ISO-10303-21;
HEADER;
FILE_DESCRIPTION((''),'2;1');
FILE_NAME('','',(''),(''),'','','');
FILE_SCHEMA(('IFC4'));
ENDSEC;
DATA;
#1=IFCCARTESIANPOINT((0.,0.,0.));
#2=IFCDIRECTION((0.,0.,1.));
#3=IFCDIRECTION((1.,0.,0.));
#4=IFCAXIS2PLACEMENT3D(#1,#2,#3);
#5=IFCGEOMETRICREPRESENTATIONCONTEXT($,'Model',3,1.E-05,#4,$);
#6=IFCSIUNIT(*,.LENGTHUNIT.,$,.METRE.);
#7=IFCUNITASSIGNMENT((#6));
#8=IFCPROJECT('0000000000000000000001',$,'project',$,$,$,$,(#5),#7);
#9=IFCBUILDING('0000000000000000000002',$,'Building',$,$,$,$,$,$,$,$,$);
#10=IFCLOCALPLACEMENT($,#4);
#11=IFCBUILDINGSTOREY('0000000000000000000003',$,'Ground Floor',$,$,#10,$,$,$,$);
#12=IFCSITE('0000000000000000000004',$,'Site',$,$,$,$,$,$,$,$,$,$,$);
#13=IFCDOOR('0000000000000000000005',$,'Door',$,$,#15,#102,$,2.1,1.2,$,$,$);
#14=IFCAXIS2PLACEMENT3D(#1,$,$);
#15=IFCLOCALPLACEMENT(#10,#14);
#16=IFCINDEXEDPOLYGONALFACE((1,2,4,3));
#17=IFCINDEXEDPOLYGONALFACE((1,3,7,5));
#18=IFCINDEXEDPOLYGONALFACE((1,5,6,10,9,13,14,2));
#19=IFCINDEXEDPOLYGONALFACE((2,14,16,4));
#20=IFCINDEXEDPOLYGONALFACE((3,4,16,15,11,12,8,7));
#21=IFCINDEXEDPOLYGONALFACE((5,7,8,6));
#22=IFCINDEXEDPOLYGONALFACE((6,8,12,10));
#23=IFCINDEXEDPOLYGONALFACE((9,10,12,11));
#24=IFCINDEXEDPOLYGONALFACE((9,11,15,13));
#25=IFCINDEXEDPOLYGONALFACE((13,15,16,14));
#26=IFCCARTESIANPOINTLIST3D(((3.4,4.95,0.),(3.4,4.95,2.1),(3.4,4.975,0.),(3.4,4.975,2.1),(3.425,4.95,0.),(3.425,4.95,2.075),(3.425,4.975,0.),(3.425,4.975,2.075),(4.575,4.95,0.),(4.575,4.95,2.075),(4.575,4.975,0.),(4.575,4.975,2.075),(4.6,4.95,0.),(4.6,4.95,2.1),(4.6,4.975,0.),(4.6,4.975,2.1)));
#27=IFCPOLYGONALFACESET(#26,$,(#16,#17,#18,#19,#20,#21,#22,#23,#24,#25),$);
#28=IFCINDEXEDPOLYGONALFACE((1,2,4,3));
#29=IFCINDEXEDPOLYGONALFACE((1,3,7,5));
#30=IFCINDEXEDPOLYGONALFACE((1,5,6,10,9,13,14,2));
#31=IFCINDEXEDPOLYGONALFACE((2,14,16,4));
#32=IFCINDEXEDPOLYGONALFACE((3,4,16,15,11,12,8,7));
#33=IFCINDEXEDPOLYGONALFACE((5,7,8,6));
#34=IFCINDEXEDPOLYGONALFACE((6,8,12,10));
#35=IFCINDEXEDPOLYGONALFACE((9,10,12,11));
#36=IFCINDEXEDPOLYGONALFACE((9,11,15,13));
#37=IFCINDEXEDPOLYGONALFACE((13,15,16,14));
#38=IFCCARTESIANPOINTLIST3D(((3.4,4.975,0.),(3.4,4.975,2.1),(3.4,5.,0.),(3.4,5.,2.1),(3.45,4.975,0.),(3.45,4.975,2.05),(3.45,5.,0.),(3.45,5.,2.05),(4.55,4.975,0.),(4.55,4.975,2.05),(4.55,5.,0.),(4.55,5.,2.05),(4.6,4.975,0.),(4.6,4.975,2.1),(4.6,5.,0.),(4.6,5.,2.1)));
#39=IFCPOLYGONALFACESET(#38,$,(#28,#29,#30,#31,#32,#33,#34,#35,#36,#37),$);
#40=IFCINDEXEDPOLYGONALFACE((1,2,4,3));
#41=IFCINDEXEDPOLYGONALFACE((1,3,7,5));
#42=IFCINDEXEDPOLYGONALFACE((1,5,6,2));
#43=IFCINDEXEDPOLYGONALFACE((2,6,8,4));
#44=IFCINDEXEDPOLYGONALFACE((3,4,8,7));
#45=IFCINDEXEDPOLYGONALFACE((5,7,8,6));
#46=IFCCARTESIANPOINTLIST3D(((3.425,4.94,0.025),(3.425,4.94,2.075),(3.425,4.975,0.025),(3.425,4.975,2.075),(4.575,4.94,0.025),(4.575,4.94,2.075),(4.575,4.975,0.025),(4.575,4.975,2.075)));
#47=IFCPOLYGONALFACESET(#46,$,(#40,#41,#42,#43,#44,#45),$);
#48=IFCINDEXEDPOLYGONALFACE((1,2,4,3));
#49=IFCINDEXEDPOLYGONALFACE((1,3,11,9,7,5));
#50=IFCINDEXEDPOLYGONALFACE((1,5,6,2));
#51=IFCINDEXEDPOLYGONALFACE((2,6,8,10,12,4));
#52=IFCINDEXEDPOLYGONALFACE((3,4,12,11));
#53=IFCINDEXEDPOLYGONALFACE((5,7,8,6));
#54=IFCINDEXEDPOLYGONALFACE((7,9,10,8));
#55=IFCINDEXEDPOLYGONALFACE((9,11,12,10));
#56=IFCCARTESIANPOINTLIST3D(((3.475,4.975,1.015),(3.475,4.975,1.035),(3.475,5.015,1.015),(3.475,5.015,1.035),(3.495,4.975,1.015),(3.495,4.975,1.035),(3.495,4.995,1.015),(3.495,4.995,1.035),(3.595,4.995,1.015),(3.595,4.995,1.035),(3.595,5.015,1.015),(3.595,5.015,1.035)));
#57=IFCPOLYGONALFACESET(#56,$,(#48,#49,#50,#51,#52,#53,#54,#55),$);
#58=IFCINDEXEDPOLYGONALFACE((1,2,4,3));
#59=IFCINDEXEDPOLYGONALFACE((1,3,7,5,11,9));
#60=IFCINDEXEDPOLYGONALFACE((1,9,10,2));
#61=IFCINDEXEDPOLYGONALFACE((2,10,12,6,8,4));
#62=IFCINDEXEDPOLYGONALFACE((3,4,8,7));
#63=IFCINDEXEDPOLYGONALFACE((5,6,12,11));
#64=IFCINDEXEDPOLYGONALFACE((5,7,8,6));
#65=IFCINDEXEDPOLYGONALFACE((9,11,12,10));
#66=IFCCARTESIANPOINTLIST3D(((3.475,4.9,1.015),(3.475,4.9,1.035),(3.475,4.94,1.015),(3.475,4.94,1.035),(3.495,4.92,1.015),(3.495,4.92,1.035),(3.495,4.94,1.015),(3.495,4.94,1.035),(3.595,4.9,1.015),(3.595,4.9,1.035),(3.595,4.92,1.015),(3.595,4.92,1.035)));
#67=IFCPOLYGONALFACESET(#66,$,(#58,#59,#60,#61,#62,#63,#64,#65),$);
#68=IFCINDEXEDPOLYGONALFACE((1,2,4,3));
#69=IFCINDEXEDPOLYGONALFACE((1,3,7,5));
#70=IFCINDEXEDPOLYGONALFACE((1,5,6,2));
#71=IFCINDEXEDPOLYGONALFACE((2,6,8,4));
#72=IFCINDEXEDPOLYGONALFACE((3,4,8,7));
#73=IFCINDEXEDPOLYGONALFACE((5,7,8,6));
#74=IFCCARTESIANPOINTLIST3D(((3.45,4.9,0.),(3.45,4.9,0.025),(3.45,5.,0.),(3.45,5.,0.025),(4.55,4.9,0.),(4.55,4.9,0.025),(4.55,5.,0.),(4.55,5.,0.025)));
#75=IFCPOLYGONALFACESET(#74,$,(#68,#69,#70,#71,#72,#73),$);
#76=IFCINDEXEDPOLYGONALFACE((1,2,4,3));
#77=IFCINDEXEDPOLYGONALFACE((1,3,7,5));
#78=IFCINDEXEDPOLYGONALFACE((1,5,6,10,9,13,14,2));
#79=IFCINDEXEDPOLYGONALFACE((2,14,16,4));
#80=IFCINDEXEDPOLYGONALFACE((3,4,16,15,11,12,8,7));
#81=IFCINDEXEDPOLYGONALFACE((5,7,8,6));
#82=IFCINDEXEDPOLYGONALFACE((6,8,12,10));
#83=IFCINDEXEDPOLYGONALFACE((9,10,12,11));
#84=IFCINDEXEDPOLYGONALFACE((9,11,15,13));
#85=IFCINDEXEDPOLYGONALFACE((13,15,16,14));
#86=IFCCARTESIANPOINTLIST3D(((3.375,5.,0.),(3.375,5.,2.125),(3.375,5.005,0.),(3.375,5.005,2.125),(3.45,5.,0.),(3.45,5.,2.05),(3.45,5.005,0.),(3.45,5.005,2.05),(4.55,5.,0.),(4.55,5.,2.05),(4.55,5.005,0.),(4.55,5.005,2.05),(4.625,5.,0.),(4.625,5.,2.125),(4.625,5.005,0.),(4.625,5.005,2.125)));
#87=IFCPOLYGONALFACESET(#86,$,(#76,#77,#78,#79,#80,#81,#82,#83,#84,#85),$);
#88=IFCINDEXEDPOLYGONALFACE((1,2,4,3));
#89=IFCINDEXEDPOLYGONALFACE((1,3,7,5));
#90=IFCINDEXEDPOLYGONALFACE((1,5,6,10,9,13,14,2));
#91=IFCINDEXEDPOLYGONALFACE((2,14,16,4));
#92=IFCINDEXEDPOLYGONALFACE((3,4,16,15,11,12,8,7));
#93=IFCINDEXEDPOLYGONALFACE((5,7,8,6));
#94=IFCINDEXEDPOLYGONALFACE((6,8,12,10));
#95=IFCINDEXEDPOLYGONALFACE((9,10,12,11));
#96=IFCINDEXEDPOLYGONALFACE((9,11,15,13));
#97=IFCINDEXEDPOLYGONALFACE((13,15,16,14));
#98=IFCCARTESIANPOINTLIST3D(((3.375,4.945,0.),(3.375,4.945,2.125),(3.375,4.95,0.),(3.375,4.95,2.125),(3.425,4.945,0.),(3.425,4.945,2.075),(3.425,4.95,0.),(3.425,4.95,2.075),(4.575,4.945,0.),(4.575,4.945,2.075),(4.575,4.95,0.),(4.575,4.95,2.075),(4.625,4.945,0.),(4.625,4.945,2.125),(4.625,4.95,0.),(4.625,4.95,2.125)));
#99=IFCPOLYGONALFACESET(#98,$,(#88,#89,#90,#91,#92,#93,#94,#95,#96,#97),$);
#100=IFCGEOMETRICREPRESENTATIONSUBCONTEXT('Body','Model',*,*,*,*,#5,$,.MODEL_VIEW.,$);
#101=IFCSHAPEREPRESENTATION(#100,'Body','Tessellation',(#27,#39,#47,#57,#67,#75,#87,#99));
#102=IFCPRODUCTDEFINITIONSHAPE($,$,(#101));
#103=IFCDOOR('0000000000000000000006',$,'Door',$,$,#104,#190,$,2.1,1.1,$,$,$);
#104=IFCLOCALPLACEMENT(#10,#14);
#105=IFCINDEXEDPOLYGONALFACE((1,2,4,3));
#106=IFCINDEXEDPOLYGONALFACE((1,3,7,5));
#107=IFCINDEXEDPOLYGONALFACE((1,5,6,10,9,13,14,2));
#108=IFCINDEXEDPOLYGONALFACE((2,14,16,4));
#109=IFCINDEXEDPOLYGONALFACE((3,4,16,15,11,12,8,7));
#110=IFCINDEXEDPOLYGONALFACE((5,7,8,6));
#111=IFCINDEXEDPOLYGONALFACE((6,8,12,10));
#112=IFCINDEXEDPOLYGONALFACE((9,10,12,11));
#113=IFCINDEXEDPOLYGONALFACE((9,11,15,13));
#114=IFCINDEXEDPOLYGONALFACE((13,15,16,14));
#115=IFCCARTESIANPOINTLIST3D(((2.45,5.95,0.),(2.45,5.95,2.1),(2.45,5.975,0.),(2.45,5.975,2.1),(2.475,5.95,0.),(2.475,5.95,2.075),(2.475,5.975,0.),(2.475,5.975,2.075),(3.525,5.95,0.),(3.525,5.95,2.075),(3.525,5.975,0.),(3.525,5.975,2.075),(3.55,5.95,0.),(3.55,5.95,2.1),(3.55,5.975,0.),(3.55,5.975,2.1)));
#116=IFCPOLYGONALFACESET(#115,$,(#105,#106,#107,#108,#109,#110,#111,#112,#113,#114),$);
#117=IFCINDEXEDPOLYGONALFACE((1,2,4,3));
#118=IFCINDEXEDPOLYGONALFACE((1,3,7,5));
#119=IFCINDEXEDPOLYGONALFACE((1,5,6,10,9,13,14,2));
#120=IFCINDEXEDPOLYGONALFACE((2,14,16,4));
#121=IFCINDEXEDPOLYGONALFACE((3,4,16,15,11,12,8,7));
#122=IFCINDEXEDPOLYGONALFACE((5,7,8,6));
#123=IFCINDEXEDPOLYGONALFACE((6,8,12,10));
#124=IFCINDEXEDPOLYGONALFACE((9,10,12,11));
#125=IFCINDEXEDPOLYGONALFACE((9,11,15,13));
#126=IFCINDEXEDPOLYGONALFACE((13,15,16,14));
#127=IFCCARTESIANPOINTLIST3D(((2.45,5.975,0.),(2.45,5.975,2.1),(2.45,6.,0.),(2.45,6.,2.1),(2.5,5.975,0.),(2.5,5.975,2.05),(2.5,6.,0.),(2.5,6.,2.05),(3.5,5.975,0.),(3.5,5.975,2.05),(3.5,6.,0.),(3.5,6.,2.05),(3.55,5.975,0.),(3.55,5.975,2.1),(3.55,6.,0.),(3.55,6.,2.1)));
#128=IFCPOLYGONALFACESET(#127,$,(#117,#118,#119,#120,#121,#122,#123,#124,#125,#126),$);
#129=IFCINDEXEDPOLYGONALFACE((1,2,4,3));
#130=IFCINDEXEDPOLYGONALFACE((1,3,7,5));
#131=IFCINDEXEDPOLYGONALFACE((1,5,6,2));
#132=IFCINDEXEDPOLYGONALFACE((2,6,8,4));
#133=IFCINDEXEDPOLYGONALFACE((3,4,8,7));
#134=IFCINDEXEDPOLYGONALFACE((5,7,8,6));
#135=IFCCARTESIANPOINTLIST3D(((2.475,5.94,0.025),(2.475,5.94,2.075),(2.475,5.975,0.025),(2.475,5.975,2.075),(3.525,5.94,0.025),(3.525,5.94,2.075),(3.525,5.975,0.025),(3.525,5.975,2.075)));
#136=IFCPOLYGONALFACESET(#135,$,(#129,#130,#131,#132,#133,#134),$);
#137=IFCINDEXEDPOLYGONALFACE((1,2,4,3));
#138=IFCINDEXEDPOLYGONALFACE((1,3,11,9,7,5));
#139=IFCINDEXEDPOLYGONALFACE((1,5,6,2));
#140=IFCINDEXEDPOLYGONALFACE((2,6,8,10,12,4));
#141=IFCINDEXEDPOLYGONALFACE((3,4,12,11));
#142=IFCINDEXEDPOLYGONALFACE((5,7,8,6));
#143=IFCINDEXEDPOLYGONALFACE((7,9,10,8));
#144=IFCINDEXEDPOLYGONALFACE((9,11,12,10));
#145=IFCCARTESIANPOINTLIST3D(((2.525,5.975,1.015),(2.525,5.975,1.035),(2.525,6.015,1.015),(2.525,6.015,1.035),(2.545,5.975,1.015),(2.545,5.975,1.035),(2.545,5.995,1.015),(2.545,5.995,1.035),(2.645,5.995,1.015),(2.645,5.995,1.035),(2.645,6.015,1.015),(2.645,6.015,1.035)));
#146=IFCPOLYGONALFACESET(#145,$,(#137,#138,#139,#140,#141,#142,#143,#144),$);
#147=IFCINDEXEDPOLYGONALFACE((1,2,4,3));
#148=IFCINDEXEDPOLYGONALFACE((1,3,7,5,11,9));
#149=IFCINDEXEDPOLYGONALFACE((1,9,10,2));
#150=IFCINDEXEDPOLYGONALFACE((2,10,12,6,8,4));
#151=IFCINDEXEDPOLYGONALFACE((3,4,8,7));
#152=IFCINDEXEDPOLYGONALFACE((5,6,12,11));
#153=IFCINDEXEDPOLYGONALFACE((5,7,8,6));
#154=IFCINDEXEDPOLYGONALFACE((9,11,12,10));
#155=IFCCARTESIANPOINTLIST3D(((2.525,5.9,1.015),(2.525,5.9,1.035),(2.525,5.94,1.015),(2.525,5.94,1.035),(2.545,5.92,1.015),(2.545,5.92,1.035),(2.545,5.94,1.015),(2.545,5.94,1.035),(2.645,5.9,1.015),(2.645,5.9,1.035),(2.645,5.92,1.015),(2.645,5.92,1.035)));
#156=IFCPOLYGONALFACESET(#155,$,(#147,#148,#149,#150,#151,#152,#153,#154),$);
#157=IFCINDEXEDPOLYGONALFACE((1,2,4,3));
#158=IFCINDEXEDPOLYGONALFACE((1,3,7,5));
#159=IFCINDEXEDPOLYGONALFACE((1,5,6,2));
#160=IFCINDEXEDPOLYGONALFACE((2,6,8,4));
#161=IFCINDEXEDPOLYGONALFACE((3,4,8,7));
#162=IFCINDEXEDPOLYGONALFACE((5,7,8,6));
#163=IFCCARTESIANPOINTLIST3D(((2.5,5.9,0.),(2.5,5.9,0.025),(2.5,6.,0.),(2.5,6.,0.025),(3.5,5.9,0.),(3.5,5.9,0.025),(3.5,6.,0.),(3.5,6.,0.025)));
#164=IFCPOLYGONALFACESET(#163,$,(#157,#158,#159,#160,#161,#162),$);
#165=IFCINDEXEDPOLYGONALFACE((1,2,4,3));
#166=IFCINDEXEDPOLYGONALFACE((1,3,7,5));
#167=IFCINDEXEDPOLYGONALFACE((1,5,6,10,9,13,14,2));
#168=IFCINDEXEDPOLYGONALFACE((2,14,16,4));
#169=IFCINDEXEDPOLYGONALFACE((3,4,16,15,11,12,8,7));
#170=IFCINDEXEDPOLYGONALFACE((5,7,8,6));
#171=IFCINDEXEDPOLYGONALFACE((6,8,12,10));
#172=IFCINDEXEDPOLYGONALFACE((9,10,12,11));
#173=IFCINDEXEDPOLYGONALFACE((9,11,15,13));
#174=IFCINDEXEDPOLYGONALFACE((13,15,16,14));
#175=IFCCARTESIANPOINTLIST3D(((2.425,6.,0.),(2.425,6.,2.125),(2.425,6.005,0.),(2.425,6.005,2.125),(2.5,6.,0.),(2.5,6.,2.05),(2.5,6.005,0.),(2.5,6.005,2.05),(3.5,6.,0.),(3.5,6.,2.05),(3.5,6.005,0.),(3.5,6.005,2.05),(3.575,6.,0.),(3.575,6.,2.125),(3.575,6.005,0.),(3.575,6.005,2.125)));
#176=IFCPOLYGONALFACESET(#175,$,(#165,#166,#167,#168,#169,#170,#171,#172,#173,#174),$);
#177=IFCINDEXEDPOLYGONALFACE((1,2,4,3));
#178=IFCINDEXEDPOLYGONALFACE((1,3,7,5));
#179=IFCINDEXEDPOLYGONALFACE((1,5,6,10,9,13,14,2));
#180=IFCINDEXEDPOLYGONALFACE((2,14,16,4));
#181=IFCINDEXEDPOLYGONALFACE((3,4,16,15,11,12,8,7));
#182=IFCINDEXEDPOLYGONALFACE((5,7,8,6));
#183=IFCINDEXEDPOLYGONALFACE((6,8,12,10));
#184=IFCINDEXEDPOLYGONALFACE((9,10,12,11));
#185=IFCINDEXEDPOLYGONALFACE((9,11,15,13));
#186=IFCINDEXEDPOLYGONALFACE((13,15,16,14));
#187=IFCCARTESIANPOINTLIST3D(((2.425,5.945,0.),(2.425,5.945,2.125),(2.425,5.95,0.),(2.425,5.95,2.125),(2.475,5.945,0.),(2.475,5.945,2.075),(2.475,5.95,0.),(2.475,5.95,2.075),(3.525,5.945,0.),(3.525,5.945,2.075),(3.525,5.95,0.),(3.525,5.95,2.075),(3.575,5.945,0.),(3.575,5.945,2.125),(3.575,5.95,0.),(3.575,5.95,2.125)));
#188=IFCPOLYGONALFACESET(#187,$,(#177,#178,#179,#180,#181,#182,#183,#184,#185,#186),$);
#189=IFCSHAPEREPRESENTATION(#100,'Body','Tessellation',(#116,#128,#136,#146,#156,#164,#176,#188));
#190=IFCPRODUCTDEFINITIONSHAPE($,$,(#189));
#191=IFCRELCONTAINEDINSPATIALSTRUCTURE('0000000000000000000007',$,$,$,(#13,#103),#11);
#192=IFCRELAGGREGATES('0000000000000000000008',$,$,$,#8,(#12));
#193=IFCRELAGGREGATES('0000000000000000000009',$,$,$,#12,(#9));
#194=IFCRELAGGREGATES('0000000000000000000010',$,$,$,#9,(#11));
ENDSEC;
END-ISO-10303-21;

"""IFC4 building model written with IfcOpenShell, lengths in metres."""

from ifc_helpers import new_model, si_unit, frame, origin_with_axes, place, context, subcontext, project, spatial, line, indexed_curve, outline, extrude, element, save


model = new_model("IFC4")

# Units and contexts
model_context = context("Model", 3, precision=1e-05, world=origin_with_axes())
body_context = subcontext(model_context, "Body", "Model", "MODEL_VIEW")
ifc_project = project(units=[si_unit("LENGTHUNIT", "METRE")], contexts=[model_context])

# Site, building, storey
site = spatial("IfcSite", under=ifc_project, Name="Site")
building = spatial("IfcBuilding", under=site, Name="Building")
storey_placement = place(None, origin_with_axes())
storey = spatial("IfcBuildingStorey", under=building, at=storey_placement, Name="Ground Floor")

# Doors
door_1_placement = place(storey_placement, frame((4.6, 5.0, 0.0), z_axis=(0.0, 0.0, 1.0), x_axis=(-1.0, 0.0, 0.0)))
element("IfcDoor", 1, at=door_1_placement, inside=storey, Name="Door", OverallHeight=2.1, OverallWidth=1.2, context=body_context, shape_type="SweptSolid", body=[
    extrude(outline(indexed_curve([(0.0, 0.0), (0.0, 2.1), (1.2, 2.1), (1.2, 0.0), (1.175, 0.0), (1.175, 2.075), (0.025, 2.075), (0.025, 0.0)], segments=[line(1, 2, 3, 4, 5, 6, 7, 8, 1)])), frame((0.0, 0.025, 0.0), z_axis=(0.0, -1.0, 0.0), x_axis=(1.0, 0.0, 0.0)), (0.0, 0.0, -1.0), 0.025),
    extrude(outline(indexed_curve([(0.0, 0.0), (0.0, 2.1), (1.2, 2.1), (1.2, 0.0), (1.15, 0.0), (1.15, 2.05), (0.05, 2.05), (0.05, 0.0)], segments=[line(1, 2, 3, 4, 5, 6, 7, 8, 1)])), frame((0.0, 0.0, 0.0), z_axis=(0.0, -1.0, 0.0), x_axis=(1.0, 0.0, 0.0)), (0.0, 0.0, -1.0), 0.025),
    extrude(outline(indexed_curve([(0.0, 0.0), (1.15, 0.0), (1.15, 0.035), (0.0, 0.035)], segments=[line(1, 2, 3, 4, 1)])), frame((0.025, 0.025, 0.025), z_axis=(0.0, 0.0, 1.0), x_axis=(1.0, 0.0, 0.0)), (0.0, 0.0, 1.0), 2.05),
    extrude(outline(indexed_curve([(0.0, 0.0), (0.0, -0.04), (-0.12, -0.04), (-0.12, -0.02), (-0.02, -0.02), (-0.02, 0.0)], segments=[line(1, 2, 3, 4, 5, 6, 1)])), frame((1.125, 0.025, 1.015), z_axis=(0.0, 0.0, 1.0), x_axis=(1.0, 0.0, 0.0)), (0.0, 0.0, 1.0), 0.02),
    extrude(outline(indexed_curve([(0.0, 0.0), (0.0, 0.04), (-0.12, 0.04), (-0.12, 0.02), (-0.02, 0.02), (-0.02, 0.0)], segments=[line(1, 2, 3, 4, 5, 6, 1)])), frame((1.125, 0.06, 1.015), z_axis=(0.0, 0.0, 1.0), x_axis=(1.0, 0.0, 0.0)), (0.0, 0.0, 1.0), 0.02),
    extrude(outline(indexed_curve([(0.0, 0.0), (1.1, 0.0), (1.1, 0.1), (0.0, 0.1)], segments=[line(1, 2, 3, 4, 1)])), frame((0.05, 0.0, 0.0), z_axis=(0.0, 0.0, 1.0), x_axis=(1.0, 0.0, 0.0)), (0.0, 0.0, 1.0), 0.025),
    extrude(outline(indexed_curve([(0.0, 0.0), (0.0, 2.125), (1.25, 2.125), (1.25, 0.0), (1.175, 0.0), (1.175, 2.05), (0.075, 2.05), (0.075, 0.0)], segments=[line(1, 2, 3, 4, 5, 6, 7, 8, 1)])), frame((-0.025, -0.005, 0.0), z_axis=(0.0, -1.0, 0.0), x_axis=(1.0, 0.0, 0.0)), (0.0, 0.0, -1.0), 0.005),
    extrude(outline(indexed_curve([(0.0, 0.0), (0.0, 2.125), (1.25, 2.125), (1.25, 0.0), (1.2, 0.0), (1.2, 2.075), (0.05, 2.075), (0.05, 0.0)], segments=[line(1, 2, 3, 4, 5, 6, 7, 8, 1)])), frame((-0.025, 0.05, 0.0), z_axis=(0.0, -1.0, 0.0), x_axis=(1.0, 0.0, 0.0)), (0.0, 0.0, -1.0), 0.005),
])
door_2_placement = place(storey_placement, frame((3.55, 6.0, 0.0), z_axis=(0.0, 0.0, 1.0), x_axis=(-1.0, 0.0, 0.0)))
element("IfcDoor", 2, at=door_2_placement, inside=storey, Name="Door", OverallHeight=2.1, OverallWidth=1.1, context=body_context, shape_type="SweptSolid", body=[
    extrude(outline(indexed_curve([(0.0, 0.0), (0.0, 2.1), (1.1, 2.1), (1.1, 0.0), (1.075, 0.0), (1.075, 2.075), (0.025, 2.075), (0.025, 0.0)], segments=[line(1, 2, 3, 4, 5, 6, 7, 8, 1)])), frame((0.0, 0.025, 0.0), z_axis=(0.0, -1.0, 0.0), x_axis=(1.0, 0.0, 0.0)), (0.0, 0.0, -1.0), 0.025),
    extrude(outline(indexed_curve([(0.0, 0.0), (0.0, 2.1), (1.1, 2.1), (1.1, 0.0), (1.05, 0.0), (1.05, 2.05), (0.05, 2.05), (0.05, 0.0)], segments=[line(1, 2, 3, 4, 5, 6, 7, 8, 1)])), frame((0.0, 0.0, 0.0), z_axis=(0.0, -1.0, 0.0), x_axis=(1.0, 0.0, 0.0)), (0.0, 0.0, -1.0), 0.025),
    extrude(outline(indexed_curve([(0.0, 0.0), (1.05, 0.0), (1.05, 0.035), (0.0, 0.035)], segments=[line(1, 2, 3, 4, 1)])), frame((0.025, 0.025, 0.025), z_axis=(0.0, 0.0, 1.0), x_axis=(1.0, 0.0, 0.0)), (0.0, 0.0, 1.0), 2.05),
    extrude(outline(indexed_curve([(0.0, 0.0), (0.0, -0.04), (-0.12, -0.04), (-0.12, -0.02), (-0.02, -0.02), (-0.02, 0.0)], segments=[line(1, 2, 3, 4, 5, 6, 1)])), frame((1.025, 0.025, 1.015), z_axis=(0.0, 0.0, 1.0), x_axis=(1.0, 0.0, 0.0)), (0.0, 0.0, 1.0), 0.02),
    extrude(outline(indexed_curve([(0.0, 0.0), (0.0, 0.04), (-0.12, 0.04), (-0.12, 0.02), (-0.02, 0.02), (-0.02, 0.0)], segments=[line(1, 2, 3, 4, 5, 6, 1)])), frame((1.025, 0.06, 1.015), z_axis=(0.0, 0.0, 1.0), x_axis=(1.0, 0.0, 0.0)), (0.0, 0.0, 1.0), 0.02),
    extrude(outline(indexed_curve([(0.0, 0.0), (1.0, 0.0), (1.0, 0.1), (0.0, 0.1)], segments=[line(1, 2, 3, 4, 1)])), frame((0.05, 0.0, 0.0), z_axis=(0.0, 0.0, 1.0), x_axis=(1.0, 0.0, 0.0)), (0.0, 0.0, 1.0), 0.025),
    extrude(outline(indexed_curve([(0.0, 0.0), (0.0, 2.125), (1.15, 2.125), (1.15, 0.0), (1.075, 0.0), (1.075, 2.05), (0.075, 2.05), (0.075, 0.0)], segments=[line(1, 2, 3, 4, 5, 6, 7, 8, 1)])), frame((-0.025, -0.005, 0.0), z_axis=(0.0, -1.0, 0.0), x_axis=(1.0, 0.0, 0.0)), (0.0, 0.0, -1.0), 0.005),
    extrude(outline(indexed_curve([(0.0, 0.0), (0.0, 2.125), (1.15, 2.125), (1.15, 0.0), (1.1, 0.0), (1.1, 2.075), (0.05, 2.075), (0.05, 0.0)], segments=[line(1, 2, 3, 4, 5, 6, 7, 8, 1)])), frame((-0.025, 0.05, 0.0), z_axis=(0.0, -1.0, 0.0), x_axis=(1.0, 0.0, 0.0)), (0.0, 0.0, -1.0), 0.005),
])

save(model, "model.ifc")
